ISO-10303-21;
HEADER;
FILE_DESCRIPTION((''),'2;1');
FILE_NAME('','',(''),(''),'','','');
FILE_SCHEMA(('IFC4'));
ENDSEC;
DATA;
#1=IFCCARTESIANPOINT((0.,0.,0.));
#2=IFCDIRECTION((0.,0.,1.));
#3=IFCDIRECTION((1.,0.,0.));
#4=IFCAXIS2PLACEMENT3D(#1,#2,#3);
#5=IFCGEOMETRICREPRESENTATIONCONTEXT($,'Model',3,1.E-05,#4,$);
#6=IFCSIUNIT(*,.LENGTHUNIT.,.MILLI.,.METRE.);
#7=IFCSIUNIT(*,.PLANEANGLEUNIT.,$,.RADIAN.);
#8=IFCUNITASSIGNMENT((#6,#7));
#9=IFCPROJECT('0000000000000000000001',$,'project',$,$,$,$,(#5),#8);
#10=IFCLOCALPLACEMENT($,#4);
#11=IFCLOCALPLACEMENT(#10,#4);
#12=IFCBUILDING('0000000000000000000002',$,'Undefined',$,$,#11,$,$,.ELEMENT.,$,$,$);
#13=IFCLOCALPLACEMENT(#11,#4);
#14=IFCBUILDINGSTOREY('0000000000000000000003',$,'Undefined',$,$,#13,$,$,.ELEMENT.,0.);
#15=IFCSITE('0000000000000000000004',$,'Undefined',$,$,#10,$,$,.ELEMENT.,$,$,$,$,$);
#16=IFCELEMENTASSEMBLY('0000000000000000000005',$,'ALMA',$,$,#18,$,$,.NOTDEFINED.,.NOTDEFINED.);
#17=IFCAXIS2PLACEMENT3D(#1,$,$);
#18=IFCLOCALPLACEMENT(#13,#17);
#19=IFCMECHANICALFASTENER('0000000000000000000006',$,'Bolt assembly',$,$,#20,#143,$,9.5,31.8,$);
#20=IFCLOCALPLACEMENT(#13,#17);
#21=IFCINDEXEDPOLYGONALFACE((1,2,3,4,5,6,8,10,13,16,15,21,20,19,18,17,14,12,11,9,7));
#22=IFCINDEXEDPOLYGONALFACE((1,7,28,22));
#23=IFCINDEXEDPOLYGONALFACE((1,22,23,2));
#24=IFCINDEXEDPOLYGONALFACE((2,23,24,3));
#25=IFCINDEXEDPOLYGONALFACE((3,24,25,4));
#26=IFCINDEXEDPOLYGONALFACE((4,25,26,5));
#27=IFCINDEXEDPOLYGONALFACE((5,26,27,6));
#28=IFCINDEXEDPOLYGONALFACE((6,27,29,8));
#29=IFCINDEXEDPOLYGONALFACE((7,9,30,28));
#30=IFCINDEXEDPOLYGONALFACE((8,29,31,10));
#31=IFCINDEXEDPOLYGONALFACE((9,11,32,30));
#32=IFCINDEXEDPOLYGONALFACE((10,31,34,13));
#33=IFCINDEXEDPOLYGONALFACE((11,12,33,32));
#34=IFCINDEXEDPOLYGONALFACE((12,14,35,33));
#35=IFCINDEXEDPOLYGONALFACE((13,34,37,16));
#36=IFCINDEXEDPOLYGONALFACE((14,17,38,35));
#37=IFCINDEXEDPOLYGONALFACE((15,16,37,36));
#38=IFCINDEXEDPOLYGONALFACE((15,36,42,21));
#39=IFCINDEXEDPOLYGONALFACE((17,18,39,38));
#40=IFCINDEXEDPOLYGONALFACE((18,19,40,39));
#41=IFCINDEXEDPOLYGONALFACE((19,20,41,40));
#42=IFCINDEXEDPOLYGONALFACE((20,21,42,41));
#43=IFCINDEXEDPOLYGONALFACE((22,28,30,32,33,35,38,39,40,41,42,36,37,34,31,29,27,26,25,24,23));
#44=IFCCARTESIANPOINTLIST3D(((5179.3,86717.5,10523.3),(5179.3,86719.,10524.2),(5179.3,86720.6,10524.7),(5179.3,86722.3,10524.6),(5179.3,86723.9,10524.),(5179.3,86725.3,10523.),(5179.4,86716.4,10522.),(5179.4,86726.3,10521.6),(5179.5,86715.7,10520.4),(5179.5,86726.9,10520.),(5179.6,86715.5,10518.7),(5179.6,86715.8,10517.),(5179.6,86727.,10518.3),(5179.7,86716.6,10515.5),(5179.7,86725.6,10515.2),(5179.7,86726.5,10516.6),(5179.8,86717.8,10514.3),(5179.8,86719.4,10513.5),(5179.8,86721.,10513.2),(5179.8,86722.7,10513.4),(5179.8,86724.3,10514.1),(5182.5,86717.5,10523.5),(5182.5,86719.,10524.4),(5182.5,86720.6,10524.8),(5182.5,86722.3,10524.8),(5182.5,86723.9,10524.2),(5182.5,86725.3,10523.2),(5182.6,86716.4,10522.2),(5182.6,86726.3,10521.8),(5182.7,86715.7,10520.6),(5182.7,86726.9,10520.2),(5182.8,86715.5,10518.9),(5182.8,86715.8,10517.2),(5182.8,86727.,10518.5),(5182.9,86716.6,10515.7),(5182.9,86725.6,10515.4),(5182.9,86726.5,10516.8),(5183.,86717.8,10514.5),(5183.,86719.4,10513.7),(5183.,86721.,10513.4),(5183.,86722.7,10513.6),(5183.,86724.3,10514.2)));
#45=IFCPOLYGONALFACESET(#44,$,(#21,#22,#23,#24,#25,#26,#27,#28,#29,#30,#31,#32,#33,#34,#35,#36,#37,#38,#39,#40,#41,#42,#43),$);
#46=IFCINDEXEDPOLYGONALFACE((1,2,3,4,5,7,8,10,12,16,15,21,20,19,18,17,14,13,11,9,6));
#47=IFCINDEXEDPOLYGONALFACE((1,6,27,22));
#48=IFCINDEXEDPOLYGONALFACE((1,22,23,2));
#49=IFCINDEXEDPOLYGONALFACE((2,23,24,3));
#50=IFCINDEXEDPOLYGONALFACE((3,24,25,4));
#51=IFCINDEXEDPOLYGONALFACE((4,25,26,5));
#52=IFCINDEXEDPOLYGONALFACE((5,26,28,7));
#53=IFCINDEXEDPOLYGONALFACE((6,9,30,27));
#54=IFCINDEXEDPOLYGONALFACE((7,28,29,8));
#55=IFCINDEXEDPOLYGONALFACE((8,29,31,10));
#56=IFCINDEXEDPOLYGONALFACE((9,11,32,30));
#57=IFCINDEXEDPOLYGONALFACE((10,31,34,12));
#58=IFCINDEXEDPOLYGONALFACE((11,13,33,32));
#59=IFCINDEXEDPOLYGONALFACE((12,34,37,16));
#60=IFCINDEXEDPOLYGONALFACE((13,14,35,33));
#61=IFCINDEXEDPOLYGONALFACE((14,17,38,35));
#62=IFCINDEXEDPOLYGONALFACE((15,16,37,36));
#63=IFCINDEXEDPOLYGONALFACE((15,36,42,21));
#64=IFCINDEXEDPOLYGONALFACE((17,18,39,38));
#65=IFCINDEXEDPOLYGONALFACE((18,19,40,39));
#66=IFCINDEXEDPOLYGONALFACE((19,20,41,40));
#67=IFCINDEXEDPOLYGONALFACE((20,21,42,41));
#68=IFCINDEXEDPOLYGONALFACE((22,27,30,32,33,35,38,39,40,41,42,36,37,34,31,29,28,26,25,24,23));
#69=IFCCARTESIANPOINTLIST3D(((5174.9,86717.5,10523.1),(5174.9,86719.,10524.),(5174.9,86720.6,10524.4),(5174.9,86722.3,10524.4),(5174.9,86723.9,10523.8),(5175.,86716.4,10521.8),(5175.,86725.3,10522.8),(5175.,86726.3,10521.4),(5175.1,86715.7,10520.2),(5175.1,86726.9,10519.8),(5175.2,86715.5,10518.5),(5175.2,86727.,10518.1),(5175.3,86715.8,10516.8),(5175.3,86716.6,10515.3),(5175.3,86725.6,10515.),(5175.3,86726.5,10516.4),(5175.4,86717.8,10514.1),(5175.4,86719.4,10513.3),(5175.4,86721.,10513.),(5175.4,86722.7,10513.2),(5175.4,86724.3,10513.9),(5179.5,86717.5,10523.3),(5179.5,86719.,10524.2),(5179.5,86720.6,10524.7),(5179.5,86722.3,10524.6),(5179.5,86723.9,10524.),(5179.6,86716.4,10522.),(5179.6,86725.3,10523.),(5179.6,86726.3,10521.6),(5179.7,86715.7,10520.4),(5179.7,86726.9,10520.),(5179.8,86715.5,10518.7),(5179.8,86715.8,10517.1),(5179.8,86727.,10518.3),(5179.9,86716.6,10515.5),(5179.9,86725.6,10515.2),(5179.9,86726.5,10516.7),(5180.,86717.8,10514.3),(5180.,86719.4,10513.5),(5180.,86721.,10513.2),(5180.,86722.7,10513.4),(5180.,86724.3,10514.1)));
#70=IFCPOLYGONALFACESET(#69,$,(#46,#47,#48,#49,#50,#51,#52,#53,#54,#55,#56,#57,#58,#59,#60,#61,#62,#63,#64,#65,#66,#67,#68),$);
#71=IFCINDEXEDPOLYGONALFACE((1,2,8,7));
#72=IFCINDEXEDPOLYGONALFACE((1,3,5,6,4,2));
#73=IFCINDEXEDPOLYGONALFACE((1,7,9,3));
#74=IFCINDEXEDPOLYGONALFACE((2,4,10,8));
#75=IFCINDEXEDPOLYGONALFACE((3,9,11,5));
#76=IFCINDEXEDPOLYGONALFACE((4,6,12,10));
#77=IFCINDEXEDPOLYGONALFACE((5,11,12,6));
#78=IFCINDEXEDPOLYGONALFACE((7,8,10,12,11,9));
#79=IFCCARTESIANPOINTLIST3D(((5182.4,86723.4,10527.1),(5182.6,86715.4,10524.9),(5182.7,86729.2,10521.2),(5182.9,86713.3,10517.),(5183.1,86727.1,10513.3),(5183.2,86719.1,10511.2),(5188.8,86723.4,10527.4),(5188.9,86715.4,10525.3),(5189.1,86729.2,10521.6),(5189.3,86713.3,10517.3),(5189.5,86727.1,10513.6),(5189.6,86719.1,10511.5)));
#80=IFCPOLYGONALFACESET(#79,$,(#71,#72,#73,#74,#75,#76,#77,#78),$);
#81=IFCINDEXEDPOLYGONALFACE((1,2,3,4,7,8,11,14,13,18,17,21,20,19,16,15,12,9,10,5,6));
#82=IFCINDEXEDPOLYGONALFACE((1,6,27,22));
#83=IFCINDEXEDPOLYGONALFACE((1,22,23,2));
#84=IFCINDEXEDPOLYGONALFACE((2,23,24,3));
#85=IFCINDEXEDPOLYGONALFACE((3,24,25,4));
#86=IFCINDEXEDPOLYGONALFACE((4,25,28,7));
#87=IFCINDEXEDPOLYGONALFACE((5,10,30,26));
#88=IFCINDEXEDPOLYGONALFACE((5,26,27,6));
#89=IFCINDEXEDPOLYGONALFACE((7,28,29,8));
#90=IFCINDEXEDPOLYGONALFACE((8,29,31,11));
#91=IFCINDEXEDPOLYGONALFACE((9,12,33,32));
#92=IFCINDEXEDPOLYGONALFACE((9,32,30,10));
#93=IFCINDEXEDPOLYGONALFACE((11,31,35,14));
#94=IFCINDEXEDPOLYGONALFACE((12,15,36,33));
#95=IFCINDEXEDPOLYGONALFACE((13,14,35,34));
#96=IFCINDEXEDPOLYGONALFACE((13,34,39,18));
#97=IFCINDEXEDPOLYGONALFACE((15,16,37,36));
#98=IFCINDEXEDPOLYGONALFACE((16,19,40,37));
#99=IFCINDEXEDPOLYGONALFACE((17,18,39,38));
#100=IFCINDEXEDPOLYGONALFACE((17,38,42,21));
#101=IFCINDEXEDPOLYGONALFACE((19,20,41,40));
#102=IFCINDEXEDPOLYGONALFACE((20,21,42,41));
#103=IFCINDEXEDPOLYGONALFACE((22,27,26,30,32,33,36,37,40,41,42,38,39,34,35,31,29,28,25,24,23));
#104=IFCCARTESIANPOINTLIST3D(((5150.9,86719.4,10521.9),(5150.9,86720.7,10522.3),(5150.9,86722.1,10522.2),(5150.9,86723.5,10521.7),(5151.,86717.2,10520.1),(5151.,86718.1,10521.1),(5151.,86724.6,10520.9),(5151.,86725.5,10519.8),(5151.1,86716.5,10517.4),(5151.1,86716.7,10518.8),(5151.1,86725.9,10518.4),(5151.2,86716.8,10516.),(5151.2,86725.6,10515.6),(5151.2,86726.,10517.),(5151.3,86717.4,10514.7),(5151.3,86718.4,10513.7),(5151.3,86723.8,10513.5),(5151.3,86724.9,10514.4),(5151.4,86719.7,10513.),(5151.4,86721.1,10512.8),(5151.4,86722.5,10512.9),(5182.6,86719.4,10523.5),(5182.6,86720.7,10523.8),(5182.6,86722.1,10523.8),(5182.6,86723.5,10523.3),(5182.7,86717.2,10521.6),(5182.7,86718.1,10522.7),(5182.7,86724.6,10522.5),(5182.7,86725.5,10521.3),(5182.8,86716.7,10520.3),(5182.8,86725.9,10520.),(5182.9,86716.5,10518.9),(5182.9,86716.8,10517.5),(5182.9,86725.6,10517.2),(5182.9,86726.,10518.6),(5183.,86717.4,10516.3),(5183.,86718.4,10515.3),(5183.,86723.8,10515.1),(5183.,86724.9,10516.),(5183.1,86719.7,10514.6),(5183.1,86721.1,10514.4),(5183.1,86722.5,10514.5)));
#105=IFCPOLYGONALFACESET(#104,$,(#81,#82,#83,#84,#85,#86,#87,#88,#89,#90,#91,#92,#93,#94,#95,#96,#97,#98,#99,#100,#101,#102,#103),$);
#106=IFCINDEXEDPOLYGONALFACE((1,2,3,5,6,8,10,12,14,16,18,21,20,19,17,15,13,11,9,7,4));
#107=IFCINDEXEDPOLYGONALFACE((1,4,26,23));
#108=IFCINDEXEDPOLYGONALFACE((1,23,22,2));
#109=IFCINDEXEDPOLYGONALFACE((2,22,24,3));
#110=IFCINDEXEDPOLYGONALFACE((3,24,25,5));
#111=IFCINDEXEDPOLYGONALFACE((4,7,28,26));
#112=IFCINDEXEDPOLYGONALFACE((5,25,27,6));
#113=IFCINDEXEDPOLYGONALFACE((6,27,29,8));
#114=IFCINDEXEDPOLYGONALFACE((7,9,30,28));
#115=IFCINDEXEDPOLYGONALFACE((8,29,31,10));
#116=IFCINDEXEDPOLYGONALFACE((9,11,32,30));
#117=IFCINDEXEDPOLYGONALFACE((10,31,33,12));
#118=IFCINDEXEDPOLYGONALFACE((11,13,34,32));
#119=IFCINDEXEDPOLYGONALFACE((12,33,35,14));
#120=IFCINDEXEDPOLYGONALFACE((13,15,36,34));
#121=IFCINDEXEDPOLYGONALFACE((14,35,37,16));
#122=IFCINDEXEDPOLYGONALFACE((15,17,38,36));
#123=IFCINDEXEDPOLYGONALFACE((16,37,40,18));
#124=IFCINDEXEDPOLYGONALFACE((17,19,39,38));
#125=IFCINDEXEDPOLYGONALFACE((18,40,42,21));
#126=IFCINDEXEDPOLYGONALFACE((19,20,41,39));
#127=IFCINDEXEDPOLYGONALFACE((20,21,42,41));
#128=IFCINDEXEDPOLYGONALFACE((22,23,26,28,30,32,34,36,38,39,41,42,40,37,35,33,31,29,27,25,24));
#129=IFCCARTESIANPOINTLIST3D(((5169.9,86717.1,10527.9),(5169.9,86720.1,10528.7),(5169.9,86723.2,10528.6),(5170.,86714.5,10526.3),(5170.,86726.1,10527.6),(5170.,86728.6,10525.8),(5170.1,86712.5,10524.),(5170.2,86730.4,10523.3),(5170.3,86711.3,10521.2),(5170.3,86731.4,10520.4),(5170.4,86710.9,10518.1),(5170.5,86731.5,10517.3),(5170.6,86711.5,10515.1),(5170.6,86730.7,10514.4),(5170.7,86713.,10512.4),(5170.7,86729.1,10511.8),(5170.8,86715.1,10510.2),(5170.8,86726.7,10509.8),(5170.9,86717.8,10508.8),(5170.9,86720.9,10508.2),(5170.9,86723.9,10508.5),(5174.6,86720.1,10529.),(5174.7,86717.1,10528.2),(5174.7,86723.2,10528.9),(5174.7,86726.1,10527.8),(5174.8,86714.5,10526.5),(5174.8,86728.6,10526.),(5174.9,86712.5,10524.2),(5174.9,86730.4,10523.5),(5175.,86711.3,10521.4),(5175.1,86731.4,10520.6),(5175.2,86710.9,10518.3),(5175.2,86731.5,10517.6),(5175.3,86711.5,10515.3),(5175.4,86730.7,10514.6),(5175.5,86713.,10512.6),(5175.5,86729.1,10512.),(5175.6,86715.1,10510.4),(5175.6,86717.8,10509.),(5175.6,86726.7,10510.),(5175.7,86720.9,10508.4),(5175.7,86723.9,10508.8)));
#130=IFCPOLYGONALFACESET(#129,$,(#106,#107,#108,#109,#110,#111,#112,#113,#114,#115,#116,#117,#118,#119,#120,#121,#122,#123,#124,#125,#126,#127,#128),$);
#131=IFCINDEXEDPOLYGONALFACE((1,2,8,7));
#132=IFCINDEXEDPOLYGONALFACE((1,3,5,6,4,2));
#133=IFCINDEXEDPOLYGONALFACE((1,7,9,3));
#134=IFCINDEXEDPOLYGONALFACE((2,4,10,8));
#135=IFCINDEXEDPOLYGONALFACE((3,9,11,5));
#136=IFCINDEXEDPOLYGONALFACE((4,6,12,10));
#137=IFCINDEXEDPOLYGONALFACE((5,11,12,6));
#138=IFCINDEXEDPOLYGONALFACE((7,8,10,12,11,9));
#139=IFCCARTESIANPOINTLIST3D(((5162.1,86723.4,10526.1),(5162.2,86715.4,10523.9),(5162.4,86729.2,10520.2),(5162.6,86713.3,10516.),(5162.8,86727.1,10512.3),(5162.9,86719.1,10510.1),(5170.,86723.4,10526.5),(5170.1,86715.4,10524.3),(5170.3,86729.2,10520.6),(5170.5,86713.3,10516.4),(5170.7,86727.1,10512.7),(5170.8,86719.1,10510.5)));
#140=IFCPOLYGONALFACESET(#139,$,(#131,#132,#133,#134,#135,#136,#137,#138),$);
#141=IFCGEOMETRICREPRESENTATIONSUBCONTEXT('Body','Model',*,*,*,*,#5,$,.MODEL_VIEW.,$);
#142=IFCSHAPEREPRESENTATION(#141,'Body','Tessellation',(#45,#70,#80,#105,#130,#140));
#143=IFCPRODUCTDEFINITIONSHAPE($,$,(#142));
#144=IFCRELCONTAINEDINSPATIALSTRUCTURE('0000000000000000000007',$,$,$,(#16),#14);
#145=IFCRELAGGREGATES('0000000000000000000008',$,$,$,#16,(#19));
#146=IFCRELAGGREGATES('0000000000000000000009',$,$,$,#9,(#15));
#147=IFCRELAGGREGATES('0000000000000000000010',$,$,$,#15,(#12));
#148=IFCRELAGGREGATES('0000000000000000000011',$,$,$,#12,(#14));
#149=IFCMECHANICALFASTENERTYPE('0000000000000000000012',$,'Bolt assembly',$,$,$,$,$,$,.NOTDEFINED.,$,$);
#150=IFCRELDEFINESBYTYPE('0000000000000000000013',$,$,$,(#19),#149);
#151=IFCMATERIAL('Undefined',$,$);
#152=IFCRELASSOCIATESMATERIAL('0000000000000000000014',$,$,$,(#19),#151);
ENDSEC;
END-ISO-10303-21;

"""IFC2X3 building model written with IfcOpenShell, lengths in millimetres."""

from ifc_helpers import new_model, si_unit, frame, origin_with_axes, origin_2d_with_axis, place, context, subcontext, project, spatial, polyline, circle, outline, extrude, source, transform, mapped, material, type_object, element, aggregate, save


model = new_model("IFC2X3")

# Units and contexts
model_context = context("Model", 3, precision=1e-05, world=origin_with_axes())
body_context = subcontext(model_context, "Body", "Model", "MODEL_VIEW")
ifc_project = project(units=[si_unit("LENGTHUNIT", "METRE", prefix="MILLI"), si_unit("PLANEANGLEUNIT", "RADIAN")], contexts=[model_context])

# Site, building, storey
site_placement = place(None, origin_with_axes())
site = spatial("IfcSite", under=ifc_project, at=site_placement, Name="Undefined", CompositionType="ELEMENT")
building_placement = place(site_placement, origin_with_axes())
building = spatial("IfcBuilding", under=site, at=building_placement, Name="Undefined", CompositionType="ELEMENT")
storey_placement = place(building_placement, origin_with_axes())
storey = spatial("IfcBuildingStorey", under=building, at=storey_placement, Name="Undefined", CompositionType="ELEMENT", Elevation=0.0)

# Element assembly
assembly_1_placement = place(storey_placement, origin_with_axes())
assembly_1 = element("IfcElementAssembly", 1, at=assembly_1_placement, inside=storey, Name="ALMA", AssemblyPlace="NOTDEFINED", PredefinedType="NOTDEFINED")

# Shared definitions
ifc_material_1 = material(Name="Undefined")
mechanical_fastener_type = type_object("IfcMechanicalFastenerType", Name="Bolt assembly")

# Mechanical fastener
shared_shape_1 = source(origin_with_axes(), body_context, "Body", "SweptSolid", [
    extrude(circle(Radius=5.8, at=origin_2d_with_axis()), frame((0.0, -7.6, 0.0), z_axis=(0.0, 1.0, 0.0), x_axis=(1.0, 0.0, 0.0)), (0.0, 0.0, 1.0), 3.2),
    extrude(circle(Radius=5.8, at=origin_2d_with_axis()), frame((0.0, -4.6, 0.0), z_axis=(0.0, 1.0, 0.0), x_axis=(1.0, 0.0, 0.0)), (0.0, 0.0, 1.0), 4.6),
    extrude(outline(polyline([(7.1, -4.1), (7.1, 4.1), (0.0, 8.2), (-7.1, 4.1), (-7.1, -4.1), (0.0, -8.2), (7.1, -4.1)])), frame((0.0, -14.0, 0.0), z_axis=(0.0, 1.0, 0.0), x_axis=(1.0, 0.0, 0.0)), (0.0, 0.0, 1.0), 6.3),
    extrude(circle(Radius=4.8, at=origin_2d_with_axis()), frame((0.0, -7.7, 0.0), z_axis=(0.0, 1.0, 0.0), x_axis=(1.0, 0.0, 0.0)), (0.0, 0.0, 1.0), 31.8),
    extrude(circle(Radius=10.3, at=origin_2d_with_axis()), frame((0.0, 0.0, 0.0), z_axis=(0.0, 1.0, 0.0), x_axis=(1.0, 0.0, 0.0)), (0.0, 0.0, 1.0), 4.8),
    extrude(outline(polyline([(7.1, -4.1), (7.1, 4.1), (0.0, 8.2), (-7.1, 4.1), (-7.1, -4.1), (0.0, -8.2), (7.1, -4.1)])), frame((0.0, 4.8, 0.0), z_axis=(0.0, 1.0, 0.0), x_axis=(1.0, 0.0, 0.0)), (0.0, 0.0, 1.0), 7.9),
])
mechanical_fastener_1_placement = place(assembly_1_placement, frame((5175.2, 86721.3, 10518.7), z_axis=(-0.035282, -0.707107, 0.706226), x_axis=(-0.035281, 0.707107, 0.706226)))
mechanical_fastener_1 = element("IfcMechanicalFastener", 2, at=mechanical_fastener_1_placement, type_object=mechanical_fastener_type, material=ifc_material_1, Name="Bolt assembly", NominalDiameter=9.5, NominalLength=31.8, context=body_context, shape_type="MappedRepresentation", body=[
    mapped(shared_shape_1, transform((0.0, 0.0, 0.0))),
])
aggregate(assembly_1, [mechanical_fastener_1])

save(model, "model.ifc")
